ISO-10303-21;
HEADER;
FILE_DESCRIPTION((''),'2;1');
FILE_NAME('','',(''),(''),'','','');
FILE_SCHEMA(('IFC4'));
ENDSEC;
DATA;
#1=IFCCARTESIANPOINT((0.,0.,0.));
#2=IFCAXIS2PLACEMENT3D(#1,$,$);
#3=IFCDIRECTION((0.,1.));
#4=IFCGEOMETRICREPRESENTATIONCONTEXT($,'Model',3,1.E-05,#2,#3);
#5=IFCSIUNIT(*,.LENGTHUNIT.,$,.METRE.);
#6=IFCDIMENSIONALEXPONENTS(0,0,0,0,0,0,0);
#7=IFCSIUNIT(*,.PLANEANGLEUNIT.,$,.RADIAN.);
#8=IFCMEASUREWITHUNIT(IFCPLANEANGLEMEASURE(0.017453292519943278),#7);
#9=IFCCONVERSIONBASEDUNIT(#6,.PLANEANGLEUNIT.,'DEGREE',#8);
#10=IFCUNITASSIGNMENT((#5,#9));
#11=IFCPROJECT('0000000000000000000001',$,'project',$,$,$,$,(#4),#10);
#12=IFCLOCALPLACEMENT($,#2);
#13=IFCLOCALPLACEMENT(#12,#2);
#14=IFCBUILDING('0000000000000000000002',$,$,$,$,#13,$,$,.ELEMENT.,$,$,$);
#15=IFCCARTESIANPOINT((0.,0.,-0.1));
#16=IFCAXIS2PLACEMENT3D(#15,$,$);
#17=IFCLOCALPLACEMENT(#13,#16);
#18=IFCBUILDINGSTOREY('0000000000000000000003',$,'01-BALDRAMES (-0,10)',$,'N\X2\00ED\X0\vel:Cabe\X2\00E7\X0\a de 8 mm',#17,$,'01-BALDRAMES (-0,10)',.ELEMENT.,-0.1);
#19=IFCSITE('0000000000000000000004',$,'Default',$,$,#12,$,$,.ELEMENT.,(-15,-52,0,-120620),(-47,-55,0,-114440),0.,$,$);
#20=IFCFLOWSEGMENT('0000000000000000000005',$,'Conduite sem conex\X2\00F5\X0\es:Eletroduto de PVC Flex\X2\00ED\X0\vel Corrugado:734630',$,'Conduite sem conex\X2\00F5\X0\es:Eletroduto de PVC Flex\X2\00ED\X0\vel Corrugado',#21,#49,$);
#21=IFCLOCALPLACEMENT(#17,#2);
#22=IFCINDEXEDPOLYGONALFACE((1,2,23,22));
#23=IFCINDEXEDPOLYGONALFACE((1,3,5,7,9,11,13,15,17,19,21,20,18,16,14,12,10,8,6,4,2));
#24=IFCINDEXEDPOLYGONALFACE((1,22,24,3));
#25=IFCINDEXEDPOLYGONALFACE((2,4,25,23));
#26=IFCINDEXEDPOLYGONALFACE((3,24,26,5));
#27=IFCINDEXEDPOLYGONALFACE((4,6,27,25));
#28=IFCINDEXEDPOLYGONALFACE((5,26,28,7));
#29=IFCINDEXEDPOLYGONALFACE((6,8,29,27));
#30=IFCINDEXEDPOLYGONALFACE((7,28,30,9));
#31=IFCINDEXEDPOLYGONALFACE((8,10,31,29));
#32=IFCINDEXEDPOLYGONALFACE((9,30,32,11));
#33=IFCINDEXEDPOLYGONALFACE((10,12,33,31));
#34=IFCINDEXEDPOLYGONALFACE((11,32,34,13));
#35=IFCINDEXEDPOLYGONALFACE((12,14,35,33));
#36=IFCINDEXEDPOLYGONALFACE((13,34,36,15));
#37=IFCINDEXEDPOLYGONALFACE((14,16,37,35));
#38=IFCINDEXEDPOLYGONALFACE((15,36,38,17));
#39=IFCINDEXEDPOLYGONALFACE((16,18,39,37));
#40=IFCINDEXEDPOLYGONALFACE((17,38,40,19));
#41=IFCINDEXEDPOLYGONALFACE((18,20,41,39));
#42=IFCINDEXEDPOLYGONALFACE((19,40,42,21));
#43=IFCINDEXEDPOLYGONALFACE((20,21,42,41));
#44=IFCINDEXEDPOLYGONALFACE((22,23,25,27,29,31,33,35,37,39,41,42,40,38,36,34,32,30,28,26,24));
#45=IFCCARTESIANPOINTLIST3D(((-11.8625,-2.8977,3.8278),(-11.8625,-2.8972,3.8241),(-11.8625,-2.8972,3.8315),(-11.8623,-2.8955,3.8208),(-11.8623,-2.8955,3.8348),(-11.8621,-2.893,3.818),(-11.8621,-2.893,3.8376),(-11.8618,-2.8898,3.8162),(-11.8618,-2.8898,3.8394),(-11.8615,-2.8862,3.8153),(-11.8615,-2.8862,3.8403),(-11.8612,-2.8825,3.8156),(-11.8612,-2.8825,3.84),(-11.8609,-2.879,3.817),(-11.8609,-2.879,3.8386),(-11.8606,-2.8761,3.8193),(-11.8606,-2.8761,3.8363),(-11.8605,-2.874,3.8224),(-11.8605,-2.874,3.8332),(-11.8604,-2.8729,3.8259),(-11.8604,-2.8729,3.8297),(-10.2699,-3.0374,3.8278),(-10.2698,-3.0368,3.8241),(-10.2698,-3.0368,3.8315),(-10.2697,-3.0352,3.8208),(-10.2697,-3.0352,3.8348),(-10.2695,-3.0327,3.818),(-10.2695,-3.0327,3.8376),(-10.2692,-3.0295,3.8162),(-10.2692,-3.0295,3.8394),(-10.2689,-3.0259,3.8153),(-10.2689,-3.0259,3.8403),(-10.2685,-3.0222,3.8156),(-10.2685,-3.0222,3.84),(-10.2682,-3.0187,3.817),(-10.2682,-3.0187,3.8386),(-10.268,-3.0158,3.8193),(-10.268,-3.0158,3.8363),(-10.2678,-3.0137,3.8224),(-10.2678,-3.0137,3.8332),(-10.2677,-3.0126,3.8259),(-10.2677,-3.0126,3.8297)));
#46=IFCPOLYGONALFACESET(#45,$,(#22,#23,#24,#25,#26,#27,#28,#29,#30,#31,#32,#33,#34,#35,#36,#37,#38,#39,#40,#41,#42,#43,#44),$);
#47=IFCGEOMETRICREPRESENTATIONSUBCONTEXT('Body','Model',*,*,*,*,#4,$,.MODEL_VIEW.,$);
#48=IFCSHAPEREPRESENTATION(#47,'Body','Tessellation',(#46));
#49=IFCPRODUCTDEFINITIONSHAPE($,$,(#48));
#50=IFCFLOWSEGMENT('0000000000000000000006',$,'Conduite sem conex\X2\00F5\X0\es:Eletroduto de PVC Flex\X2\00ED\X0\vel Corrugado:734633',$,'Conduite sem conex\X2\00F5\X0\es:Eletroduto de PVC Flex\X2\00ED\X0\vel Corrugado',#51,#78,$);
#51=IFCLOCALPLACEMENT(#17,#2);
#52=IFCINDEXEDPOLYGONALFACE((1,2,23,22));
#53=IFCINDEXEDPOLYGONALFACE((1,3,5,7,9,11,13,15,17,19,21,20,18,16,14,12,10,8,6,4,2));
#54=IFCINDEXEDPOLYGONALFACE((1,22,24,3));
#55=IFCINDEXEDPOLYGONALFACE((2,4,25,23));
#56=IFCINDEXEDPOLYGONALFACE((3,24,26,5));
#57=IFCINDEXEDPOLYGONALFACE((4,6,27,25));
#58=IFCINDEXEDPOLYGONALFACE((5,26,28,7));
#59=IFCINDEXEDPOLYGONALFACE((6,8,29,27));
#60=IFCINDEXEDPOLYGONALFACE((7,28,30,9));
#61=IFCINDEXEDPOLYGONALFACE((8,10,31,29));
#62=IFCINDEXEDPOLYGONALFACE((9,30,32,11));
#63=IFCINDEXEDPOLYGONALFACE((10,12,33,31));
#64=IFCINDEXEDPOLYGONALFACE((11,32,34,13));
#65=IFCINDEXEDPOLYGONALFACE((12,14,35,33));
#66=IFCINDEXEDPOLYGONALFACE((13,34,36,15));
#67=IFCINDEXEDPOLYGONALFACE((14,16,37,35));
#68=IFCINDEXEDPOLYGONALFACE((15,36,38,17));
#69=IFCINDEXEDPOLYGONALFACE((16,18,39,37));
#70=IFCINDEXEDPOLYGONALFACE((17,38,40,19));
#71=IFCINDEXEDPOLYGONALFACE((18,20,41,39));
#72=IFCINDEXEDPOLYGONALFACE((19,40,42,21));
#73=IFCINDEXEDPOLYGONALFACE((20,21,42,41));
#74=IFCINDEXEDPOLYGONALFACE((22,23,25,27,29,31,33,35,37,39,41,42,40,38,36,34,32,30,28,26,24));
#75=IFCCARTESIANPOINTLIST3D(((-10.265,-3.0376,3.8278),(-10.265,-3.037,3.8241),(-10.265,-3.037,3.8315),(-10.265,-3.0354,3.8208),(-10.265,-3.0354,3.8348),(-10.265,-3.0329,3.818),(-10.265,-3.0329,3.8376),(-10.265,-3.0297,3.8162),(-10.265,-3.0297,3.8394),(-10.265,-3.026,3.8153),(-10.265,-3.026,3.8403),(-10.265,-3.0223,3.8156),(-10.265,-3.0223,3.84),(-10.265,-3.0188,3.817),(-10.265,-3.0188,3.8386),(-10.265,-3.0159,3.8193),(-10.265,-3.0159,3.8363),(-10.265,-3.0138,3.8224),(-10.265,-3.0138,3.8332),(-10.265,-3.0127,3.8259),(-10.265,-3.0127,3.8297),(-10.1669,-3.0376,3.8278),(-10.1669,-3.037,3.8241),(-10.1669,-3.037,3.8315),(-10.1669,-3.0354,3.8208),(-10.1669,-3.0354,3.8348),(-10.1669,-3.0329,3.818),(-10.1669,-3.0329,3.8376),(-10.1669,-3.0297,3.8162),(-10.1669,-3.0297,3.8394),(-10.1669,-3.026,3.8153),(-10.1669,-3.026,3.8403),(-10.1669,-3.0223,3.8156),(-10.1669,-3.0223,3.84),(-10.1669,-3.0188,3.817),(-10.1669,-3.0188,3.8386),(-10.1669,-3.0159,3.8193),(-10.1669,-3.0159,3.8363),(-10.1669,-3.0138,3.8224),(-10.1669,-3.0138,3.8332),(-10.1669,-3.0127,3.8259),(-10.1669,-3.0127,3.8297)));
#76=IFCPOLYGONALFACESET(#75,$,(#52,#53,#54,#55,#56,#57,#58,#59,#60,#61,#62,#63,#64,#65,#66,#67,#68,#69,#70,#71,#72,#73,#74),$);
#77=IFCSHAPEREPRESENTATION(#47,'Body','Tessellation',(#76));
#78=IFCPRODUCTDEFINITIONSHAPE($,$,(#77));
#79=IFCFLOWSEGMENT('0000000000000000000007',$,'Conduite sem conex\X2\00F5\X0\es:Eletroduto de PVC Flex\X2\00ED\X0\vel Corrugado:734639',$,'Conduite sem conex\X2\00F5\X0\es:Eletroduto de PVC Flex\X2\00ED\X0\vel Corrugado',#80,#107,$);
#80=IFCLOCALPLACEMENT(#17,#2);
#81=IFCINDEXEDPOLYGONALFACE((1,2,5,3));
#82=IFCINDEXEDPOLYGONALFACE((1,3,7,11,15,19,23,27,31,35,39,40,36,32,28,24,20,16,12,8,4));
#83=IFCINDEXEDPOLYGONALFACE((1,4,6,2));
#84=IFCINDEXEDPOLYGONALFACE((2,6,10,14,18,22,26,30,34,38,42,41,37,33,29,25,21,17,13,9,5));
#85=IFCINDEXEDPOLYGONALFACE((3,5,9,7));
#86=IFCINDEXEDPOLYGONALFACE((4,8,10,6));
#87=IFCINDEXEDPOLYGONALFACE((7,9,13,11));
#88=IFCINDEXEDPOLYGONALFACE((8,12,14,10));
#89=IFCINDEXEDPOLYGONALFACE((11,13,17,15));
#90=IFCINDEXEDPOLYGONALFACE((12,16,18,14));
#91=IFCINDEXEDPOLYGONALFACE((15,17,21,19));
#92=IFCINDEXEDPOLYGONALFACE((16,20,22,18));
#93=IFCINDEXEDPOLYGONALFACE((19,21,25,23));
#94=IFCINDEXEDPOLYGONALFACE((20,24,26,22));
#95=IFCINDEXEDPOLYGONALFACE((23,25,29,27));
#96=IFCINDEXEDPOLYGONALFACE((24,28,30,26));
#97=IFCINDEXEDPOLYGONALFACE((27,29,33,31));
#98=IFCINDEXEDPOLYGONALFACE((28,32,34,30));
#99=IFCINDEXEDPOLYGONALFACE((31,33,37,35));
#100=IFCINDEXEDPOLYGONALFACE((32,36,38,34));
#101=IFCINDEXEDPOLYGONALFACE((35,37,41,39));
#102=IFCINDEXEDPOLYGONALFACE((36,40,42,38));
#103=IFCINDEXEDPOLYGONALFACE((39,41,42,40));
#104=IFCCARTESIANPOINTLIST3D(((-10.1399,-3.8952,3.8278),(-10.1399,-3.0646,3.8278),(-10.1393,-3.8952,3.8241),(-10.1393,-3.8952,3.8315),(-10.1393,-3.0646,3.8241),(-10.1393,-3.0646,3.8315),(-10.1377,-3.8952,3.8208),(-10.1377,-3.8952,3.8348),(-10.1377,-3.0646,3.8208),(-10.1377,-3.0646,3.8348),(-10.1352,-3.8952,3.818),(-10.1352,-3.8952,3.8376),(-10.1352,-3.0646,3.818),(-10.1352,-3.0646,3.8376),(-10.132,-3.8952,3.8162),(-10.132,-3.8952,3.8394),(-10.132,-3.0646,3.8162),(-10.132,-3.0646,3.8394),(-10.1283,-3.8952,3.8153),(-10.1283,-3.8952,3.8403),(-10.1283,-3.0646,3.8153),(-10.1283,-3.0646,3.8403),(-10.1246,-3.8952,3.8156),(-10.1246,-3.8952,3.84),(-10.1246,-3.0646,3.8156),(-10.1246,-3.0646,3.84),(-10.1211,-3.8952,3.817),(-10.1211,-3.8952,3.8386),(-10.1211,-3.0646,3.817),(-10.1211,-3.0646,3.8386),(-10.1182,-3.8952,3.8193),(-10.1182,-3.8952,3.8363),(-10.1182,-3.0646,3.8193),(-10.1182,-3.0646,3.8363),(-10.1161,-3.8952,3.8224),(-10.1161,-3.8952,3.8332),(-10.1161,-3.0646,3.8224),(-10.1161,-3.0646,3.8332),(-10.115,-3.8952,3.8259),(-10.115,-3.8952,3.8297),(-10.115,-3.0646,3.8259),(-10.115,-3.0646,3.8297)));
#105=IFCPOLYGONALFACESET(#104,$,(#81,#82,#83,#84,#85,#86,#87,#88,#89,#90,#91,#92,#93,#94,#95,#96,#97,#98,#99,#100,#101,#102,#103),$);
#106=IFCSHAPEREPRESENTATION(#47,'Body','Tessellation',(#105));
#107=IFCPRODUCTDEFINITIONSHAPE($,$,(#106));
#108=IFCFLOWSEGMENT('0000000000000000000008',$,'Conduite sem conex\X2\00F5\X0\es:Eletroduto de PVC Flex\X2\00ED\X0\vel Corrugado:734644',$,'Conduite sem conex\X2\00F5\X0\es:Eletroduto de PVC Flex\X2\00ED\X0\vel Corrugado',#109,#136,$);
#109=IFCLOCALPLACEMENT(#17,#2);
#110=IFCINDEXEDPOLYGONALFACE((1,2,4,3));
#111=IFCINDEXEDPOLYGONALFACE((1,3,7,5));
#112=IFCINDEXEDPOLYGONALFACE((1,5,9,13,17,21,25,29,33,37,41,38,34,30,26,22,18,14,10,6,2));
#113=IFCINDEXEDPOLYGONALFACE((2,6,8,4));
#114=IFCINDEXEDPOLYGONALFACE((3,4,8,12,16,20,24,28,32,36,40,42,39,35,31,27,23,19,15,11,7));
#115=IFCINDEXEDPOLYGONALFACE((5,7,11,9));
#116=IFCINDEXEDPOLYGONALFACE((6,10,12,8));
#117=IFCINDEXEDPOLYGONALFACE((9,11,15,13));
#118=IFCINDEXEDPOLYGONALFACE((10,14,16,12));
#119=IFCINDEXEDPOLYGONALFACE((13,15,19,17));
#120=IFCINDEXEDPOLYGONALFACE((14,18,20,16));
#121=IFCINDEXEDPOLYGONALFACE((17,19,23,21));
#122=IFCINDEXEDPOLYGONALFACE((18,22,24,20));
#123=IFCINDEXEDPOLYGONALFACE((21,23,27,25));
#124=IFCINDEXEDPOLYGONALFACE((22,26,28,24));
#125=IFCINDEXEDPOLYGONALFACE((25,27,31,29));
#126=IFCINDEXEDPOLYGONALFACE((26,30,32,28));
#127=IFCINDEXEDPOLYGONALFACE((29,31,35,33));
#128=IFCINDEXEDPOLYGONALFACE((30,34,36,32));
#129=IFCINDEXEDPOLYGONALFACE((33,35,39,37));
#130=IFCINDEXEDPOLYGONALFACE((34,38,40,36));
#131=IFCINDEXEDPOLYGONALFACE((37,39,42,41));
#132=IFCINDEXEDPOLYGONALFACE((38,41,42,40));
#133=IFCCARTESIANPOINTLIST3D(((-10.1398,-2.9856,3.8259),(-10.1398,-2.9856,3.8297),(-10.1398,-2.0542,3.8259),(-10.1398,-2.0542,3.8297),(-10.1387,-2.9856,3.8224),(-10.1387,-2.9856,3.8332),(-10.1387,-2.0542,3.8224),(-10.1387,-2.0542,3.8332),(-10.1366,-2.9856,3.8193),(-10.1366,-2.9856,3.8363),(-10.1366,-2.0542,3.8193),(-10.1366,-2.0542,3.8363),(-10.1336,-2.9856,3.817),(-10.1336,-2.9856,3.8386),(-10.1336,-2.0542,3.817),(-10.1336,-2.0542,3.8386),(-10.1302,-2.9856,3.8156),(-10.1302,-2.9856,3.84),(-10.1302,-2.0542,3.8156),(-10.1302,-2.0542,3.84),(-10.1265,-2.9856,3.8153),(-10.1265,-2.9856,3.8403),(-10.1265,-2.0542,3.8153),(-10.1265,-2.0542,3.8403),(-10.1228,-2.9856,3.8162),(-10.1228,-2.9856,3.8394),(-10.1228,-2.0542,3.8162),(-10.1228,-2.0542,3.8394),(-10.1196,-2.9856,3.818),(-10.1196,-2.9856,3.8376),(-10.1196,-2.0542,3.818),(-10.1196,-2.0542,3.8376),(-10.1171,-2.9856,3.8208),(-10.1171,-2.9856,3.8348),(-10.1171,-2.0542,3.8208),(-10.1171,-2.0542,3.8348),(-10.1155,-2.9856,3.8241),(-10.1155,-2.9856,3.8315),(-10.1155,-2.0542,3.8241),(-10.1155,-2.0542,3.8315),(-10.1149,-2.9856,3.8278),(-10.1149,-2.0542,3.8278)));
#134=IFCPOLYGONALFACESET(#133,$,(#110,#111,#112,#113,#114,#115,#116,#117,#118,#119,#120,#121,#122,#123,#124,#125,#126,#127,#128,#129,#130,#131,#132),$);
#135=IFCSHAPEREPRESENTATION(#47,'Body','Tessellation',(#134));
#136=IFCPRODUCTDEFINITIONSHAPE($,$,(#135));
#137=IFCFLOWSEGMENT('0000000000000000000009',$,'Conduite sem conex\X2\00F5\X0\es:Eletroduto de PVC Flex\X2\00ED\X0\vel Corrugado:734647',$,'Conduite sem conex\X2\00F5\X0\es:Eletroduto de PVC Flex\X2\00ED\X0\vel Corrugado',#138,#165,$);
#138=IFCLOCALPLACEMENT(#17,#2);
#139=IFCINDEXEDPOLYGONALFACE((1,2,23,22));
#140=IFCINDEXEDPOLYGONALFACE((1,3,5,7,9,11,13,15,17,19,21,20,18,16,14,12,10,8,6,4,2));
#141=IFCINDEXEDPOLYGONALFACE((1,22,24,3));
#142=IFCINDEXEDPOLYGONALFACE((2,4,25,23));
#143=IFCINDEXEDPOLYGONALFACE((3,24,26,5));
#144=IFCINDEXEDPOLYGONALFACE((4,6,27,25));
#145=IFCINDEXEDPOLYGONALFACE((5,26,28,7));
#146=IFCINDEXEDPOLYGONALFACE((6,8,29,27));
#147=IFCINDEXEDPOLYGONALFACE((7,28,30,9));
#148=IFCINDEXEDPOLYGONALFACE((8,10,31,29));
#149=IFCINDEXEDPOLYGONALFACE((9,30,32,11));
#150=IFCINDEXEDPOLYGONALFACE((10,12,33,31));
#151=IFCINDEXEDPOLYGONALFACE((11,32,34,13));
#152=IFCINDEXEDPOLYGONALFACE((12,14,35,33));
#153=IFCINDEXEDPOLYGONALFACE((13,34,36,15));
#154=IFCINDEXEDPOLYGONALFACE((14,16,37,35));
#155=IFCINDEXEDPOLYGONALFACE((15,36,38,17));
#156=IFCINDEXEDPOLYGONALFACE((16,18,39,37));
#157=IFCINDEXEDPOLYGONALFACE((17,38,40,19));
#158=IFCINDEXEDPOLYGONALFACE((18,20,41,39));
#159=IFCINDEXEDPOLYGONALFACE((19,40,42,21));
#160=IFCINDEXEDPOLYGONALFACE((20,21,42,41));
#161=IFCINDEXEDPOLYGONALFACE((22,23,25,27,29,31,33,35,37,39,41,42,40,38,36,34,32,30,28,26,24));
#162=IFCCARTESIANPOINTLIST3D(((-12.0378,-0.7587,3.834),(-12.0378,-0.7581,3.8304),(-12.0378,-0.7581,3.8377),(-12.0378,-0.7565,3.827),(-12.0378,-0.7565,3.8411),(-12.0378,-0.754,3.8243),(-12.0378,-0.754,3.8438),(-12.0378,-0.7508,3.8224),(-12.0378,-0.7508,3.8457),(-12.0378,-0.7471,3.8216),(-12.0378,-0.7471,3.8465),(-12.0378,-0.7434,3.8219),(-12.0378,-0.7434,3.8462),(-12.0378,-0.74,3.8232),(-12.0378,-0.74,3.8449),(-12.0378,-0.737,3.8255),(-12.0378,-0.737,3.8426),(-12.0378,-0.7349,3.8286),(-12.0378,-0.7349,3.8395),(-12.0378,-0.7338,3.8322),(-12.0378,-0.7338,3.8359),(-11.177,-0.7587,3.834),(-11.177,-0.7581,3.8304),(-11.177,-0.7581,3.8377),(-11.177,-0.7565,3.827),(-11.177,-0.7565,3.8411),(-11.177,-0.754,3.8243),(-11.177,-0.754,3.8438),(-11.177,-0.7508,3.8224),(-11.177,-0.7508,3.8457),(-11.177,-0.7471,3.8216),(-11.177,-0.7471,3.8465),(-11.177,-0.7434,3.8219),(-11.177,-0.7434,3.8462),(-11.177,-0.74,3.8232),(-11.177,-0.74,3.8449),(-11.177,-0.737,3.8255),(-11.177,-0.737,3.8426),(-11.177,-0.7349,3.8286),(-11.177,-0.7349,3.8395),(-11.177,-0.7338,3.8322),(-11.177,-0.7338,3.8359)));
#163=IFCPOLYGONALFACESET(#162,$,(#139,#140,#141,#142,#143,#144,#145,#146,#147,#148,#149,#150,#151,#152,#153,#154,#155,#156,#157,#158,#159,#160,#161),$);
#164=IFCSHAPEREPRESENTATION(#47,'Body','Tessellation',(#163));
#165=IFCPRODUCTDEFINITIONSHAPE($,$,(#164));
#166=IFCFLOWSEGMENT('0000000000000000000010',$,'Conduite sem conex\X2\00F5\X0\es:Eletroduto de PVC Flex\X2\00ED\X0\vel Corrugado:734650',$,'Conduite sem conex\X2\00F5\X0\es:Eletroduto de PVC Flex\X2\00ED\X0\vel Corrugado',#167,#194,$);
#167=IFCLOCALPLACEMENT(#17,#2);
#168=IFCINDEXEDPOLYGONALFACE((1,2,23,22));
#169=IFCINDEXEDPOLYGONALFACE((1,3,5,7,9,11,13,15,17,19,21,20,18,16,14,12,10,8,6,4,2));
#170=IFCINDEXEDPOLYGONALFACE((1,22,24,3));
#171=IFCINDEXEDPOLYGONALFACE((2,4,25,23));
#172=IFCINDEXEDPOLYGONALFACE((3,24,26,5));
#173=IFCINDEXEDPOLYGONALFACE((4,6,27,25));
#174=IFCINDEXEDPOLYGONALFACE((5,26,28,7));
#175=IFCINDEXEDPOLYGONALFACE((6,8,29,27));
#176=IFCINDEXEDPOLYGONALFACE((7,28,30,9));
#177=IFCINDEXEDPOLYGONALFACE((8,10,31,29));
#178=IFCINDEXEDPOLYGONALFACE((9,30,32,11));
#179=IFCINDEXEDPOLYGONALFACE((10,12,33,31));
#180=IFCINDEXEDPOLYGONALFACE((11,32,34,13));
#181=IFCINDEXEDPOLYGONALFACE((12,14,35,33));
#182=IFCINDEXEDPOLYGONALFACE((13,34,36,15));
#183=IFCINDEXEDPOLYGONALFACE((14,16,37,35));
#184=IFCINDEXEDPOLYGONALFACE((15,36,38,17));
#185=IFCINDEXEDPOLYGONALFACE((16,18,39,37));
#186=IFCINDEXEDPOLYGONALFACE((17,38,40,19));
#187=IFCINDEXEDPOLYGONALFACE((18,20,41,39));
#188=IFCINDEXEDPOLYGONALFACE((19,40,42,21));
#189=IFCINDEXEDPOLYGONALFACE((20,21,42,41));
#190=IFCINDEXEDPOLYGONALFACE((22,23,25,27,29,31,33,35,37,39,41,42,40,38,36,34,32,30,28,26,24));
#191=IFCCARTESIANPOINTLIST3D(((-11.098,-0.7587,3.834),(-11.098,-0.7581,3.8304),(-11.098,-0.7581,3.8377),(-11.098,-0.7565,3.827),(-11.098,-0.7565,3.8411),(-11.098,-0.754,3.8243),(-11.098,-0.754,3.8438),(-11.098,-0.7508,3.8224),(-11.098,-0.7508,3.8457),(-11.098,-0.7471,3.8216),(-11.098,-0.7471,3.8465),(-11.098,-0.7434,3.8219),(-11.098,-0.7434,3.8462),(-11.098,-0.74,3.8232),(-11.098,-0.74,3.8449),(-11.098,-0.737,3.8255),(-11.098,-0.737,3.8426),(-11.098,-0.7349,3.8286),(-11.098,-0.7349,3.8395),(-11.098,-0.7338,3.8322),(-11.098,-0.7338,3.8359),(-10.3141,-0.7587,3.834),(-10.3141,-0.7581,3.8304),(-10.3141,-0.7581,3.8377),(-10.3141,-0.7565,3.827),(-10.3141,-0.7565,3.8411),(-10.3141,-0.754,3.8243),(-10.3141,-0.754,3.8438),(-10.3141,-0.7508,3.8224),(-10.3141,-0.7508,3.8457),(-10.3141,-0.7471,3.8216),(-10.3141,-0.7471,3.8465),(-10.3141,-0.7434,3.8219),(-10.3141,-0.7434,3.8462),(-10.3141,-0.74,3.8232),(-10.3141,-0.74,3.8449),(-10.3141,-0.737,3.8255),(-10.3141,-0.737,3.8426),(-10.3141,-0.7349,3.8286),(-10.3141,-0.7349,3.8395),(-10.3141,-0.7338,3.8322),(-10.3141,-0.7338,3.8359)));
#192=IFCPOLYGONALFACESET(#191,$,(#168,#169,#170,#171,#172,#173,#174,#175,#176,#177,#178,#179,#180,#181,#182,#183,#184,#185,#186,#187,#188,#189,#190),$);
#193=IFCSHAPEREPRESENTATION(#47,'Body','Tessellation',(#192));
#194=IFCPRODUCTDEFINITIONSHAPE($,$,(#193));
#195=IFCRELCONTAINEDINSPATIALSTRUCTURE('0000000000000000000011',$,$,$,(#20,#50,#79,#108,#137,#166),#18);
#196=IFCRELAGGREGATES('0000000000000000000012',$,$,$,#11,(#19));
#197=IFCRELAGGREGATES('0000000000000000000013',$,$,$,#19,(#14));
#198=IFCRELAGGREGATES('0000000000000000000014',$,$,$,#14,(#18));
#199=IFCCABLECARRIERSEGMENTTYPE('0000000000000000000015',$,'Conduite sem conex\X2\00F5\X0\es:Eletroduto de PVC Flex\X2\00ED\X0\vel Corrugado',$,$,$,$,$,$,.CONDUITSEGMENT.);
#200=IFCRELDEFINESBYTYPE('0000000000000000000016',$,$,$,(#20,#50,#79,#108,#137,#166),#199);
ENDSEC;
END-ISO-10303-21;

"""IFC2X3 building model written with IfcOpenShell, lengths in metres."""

from ifc_helpers import new_model, entity, si_unit, converted_unit, direction, frame, frame_2d, origin, origin_2d_with_axis, place, context, subcontext, project, spatial, circle, extrude, type_object, element, save


model = new_model("IFC2X3")

# Units and contexts
model_context = context("Model", 3, precision=1e-05, world=origin(), true_north=direction((0.0, 1.0)))
body_context = subcontext(model_context, "Body", "Model", "MODEL_VIEW")
ifc_project = project(units=[si_unit("LENGTHUNIT", "METRE"), converted_unit("PLANEANGLEUNIT", "DEGREE", entity("IfcPlaneAngleMeasure", 0.017453292519943278), si_unit("PLANEANGLEUNIT", "RADIAN"), dimensions=[0, 0, 0, 0, 0, 0, 0])], contexts=[model_context])

# Site, building, storey
site_placement = place(None, origin())
site = spatial("IfcSite", under=ifc_project, at=site_placement, Name="Default", CompositionType="ELEMENT", RefLatitude=(-15, -52, 0, -120620), RefLongitude=(-47, -55, 0, -114440), RefElevation=0.0)
building_placement = place(site_placement, origin())
building = spatial("IfcBuilding", under=site, at=building_placement, CompositionType="ELEMENT")
storey_placement = place(building_placement, frame((0.0, 0.0, -0.1)))
storey = spatial("IfcBuildingStorey", under=building, at=storey_placement, Name="01-BALDRAMES (-0,10)", ObjectType="Nível:Cabeça de 8 mm", LongName="01-BALDRAMES (-0,10)", CompositionType="ELEMENT", Elevation=-0.1)

# Flow segments
cable_carrier_segment_type = type_object("IfcCableCarrierSegmentType", Name="Conduite sem conexões:Eletroduto de PVC Flexível Corrugado", PredefinedType="CONDUITSEGMENT")
flow_segment_1_placement = place(storey_placement, origin())
element("IfcFlowSegment", 1, at=flow_segment_1_placement, inside=storey, type_object=cable_carrier_segment_type, Name="Conduite sem conexões:Eletroduto de PVC Flexível Corrugado:734630", ObjectType="Conduite sem conexões:Eletroduto de PVC Flexível Corrugado", context=body_context, shape_type="SweptSolid", body=[
    extrude(circle(Radius=0.0125, at=origin_2d_with_axis()), frame((-11.8614, -2.8853, 3.8278), z_axis=(0.996177, -0.08736, 0.0), x_axis=(-0.08736, -0.996177, 0.0)), (0.0, 0.0, 1.0), 1.5988),
])
flow_segment_2_placement = place(storey_placement, origin())
element("IfcFlowSegment", 2, at=flow_segment_2_placement, inside=storey, type_object=cable_carrier_segment_type, Name="Conduite sem conexões:Eletroduto de PVC Flexível Corrugado:734633", ObjectType="Conduite sem conexões:Eletroduto de PVC Flexível Corrugado", context=body_context, shape_type="SweptSolid", body=[
    extrude(circle(Radius=0.0125, at=origin_2d_with_axis()), frame((-10.265, -3.0251, 3.8278), z_axis=(1.0, 0.0, 0.0), x_axis=(0.0, -1.0, 0.0)), (0.0, 0.0, 1.0), 0.0981),
])
flow_segment_3_placement = place(storey_placement, origin())
element("IfcFlowSegment", 3, at=flow_segment_3_placement, inside=storey, type_object=cable_carrier_segment_type, Name="Conduite sem conexões:Eletroduto de PVC Flexível Corrugado:734639", ObjectType="Conduite sem conexões:Eletroduto de PVC Flexível Corrugado", context=body_context, shape_type="SweptSolid", body=[
    extrude(circle(Radius=0.0125, at=frame_2d((0.0, 0.0), x_axis=(1.0, 0.0))), frame((-10.1274, -3.8952, 3.8278), z_axis=(0.0, 1.0, 0.0), x_axis=(-1.0, 0.0, 0.0)), (0.0, 0.0, 1.0), 0.8306),
])
flow_segment_4_placement = place(storey_placement, origin())
element("IfcFlowSegment", 4, at=flow_segment_4_placement, inside=storey, type_object=cable_carrier_segment_type, Name="Conduite sem conexões:Eletroduto de PVC Flexível Corrugado:734644", ObjectType="Conduite sem conexões:Eletroduto de PVC Flexível Corrugado", context=body_context, shape_type="SweptSolid", body=[
    extrude(circle(Radius=0.0125, at=origin_2d_with_axis()), frame((-10.1274, -2.9856, 3.8278), z_axis=(0.0, 1.0, 0.0), x_axis=(1.0, 0.0, 0.0)), (0.0, 0.0, 1.0), 0.9314),
])
flow_segment_5_placement = place(storey_placement, origin())
element("IfcFlowSegment", 5, at=flow_segment_5_placement, inside=storey, type_object=cable_carrier_segment_type, Name="Conduite sem conexões:Eletroduto de PVC Flexível Corrugado:734647", ObjectType="Conduite sem conexões:Eletroduto de PVC Flexível Corrugado", context=body_context, shape_type="SweptSolid", body=[
    extrude(circle(Radius=0.0125, at=origin_2d_with_axis()), frame((-12.0378, -0.7462, 3.834), z_axis=(1.0, 0.0, 0.0), x_axis=(0.0, -1.0, 0.0)), (0.0, 0.0, 1.0), 0.8608),
])
flow_segment_6_placement = place(storey_placement, origin())
element("IfcFlowSegment", 6, at=flow_segment_6_placement, inside=storey, type_object=cable_carrier_segment_type, Name="Conduite sem conexões:Eletroduto de PVC Flexível Corrugado:734650", ObjectType="Conduite sem conexões:Eletroduto de PVC Flexível Corrugado", context=body_context, shape_type="SweptSolid", body=[
    extrude(circle(Radius=0.0125, at=frame_2d((0.0, 0.0), x_axis=(1.0, 0.0))), frame((-11.098, -0.7462, 3.834), z_axis=(1.0, 0.0, 0.0), x_axis=(0.0, -1.0, 0.0)), (0.0, 0.0, 1.0), 0.7839),
])

save(model, "model.ifc")
